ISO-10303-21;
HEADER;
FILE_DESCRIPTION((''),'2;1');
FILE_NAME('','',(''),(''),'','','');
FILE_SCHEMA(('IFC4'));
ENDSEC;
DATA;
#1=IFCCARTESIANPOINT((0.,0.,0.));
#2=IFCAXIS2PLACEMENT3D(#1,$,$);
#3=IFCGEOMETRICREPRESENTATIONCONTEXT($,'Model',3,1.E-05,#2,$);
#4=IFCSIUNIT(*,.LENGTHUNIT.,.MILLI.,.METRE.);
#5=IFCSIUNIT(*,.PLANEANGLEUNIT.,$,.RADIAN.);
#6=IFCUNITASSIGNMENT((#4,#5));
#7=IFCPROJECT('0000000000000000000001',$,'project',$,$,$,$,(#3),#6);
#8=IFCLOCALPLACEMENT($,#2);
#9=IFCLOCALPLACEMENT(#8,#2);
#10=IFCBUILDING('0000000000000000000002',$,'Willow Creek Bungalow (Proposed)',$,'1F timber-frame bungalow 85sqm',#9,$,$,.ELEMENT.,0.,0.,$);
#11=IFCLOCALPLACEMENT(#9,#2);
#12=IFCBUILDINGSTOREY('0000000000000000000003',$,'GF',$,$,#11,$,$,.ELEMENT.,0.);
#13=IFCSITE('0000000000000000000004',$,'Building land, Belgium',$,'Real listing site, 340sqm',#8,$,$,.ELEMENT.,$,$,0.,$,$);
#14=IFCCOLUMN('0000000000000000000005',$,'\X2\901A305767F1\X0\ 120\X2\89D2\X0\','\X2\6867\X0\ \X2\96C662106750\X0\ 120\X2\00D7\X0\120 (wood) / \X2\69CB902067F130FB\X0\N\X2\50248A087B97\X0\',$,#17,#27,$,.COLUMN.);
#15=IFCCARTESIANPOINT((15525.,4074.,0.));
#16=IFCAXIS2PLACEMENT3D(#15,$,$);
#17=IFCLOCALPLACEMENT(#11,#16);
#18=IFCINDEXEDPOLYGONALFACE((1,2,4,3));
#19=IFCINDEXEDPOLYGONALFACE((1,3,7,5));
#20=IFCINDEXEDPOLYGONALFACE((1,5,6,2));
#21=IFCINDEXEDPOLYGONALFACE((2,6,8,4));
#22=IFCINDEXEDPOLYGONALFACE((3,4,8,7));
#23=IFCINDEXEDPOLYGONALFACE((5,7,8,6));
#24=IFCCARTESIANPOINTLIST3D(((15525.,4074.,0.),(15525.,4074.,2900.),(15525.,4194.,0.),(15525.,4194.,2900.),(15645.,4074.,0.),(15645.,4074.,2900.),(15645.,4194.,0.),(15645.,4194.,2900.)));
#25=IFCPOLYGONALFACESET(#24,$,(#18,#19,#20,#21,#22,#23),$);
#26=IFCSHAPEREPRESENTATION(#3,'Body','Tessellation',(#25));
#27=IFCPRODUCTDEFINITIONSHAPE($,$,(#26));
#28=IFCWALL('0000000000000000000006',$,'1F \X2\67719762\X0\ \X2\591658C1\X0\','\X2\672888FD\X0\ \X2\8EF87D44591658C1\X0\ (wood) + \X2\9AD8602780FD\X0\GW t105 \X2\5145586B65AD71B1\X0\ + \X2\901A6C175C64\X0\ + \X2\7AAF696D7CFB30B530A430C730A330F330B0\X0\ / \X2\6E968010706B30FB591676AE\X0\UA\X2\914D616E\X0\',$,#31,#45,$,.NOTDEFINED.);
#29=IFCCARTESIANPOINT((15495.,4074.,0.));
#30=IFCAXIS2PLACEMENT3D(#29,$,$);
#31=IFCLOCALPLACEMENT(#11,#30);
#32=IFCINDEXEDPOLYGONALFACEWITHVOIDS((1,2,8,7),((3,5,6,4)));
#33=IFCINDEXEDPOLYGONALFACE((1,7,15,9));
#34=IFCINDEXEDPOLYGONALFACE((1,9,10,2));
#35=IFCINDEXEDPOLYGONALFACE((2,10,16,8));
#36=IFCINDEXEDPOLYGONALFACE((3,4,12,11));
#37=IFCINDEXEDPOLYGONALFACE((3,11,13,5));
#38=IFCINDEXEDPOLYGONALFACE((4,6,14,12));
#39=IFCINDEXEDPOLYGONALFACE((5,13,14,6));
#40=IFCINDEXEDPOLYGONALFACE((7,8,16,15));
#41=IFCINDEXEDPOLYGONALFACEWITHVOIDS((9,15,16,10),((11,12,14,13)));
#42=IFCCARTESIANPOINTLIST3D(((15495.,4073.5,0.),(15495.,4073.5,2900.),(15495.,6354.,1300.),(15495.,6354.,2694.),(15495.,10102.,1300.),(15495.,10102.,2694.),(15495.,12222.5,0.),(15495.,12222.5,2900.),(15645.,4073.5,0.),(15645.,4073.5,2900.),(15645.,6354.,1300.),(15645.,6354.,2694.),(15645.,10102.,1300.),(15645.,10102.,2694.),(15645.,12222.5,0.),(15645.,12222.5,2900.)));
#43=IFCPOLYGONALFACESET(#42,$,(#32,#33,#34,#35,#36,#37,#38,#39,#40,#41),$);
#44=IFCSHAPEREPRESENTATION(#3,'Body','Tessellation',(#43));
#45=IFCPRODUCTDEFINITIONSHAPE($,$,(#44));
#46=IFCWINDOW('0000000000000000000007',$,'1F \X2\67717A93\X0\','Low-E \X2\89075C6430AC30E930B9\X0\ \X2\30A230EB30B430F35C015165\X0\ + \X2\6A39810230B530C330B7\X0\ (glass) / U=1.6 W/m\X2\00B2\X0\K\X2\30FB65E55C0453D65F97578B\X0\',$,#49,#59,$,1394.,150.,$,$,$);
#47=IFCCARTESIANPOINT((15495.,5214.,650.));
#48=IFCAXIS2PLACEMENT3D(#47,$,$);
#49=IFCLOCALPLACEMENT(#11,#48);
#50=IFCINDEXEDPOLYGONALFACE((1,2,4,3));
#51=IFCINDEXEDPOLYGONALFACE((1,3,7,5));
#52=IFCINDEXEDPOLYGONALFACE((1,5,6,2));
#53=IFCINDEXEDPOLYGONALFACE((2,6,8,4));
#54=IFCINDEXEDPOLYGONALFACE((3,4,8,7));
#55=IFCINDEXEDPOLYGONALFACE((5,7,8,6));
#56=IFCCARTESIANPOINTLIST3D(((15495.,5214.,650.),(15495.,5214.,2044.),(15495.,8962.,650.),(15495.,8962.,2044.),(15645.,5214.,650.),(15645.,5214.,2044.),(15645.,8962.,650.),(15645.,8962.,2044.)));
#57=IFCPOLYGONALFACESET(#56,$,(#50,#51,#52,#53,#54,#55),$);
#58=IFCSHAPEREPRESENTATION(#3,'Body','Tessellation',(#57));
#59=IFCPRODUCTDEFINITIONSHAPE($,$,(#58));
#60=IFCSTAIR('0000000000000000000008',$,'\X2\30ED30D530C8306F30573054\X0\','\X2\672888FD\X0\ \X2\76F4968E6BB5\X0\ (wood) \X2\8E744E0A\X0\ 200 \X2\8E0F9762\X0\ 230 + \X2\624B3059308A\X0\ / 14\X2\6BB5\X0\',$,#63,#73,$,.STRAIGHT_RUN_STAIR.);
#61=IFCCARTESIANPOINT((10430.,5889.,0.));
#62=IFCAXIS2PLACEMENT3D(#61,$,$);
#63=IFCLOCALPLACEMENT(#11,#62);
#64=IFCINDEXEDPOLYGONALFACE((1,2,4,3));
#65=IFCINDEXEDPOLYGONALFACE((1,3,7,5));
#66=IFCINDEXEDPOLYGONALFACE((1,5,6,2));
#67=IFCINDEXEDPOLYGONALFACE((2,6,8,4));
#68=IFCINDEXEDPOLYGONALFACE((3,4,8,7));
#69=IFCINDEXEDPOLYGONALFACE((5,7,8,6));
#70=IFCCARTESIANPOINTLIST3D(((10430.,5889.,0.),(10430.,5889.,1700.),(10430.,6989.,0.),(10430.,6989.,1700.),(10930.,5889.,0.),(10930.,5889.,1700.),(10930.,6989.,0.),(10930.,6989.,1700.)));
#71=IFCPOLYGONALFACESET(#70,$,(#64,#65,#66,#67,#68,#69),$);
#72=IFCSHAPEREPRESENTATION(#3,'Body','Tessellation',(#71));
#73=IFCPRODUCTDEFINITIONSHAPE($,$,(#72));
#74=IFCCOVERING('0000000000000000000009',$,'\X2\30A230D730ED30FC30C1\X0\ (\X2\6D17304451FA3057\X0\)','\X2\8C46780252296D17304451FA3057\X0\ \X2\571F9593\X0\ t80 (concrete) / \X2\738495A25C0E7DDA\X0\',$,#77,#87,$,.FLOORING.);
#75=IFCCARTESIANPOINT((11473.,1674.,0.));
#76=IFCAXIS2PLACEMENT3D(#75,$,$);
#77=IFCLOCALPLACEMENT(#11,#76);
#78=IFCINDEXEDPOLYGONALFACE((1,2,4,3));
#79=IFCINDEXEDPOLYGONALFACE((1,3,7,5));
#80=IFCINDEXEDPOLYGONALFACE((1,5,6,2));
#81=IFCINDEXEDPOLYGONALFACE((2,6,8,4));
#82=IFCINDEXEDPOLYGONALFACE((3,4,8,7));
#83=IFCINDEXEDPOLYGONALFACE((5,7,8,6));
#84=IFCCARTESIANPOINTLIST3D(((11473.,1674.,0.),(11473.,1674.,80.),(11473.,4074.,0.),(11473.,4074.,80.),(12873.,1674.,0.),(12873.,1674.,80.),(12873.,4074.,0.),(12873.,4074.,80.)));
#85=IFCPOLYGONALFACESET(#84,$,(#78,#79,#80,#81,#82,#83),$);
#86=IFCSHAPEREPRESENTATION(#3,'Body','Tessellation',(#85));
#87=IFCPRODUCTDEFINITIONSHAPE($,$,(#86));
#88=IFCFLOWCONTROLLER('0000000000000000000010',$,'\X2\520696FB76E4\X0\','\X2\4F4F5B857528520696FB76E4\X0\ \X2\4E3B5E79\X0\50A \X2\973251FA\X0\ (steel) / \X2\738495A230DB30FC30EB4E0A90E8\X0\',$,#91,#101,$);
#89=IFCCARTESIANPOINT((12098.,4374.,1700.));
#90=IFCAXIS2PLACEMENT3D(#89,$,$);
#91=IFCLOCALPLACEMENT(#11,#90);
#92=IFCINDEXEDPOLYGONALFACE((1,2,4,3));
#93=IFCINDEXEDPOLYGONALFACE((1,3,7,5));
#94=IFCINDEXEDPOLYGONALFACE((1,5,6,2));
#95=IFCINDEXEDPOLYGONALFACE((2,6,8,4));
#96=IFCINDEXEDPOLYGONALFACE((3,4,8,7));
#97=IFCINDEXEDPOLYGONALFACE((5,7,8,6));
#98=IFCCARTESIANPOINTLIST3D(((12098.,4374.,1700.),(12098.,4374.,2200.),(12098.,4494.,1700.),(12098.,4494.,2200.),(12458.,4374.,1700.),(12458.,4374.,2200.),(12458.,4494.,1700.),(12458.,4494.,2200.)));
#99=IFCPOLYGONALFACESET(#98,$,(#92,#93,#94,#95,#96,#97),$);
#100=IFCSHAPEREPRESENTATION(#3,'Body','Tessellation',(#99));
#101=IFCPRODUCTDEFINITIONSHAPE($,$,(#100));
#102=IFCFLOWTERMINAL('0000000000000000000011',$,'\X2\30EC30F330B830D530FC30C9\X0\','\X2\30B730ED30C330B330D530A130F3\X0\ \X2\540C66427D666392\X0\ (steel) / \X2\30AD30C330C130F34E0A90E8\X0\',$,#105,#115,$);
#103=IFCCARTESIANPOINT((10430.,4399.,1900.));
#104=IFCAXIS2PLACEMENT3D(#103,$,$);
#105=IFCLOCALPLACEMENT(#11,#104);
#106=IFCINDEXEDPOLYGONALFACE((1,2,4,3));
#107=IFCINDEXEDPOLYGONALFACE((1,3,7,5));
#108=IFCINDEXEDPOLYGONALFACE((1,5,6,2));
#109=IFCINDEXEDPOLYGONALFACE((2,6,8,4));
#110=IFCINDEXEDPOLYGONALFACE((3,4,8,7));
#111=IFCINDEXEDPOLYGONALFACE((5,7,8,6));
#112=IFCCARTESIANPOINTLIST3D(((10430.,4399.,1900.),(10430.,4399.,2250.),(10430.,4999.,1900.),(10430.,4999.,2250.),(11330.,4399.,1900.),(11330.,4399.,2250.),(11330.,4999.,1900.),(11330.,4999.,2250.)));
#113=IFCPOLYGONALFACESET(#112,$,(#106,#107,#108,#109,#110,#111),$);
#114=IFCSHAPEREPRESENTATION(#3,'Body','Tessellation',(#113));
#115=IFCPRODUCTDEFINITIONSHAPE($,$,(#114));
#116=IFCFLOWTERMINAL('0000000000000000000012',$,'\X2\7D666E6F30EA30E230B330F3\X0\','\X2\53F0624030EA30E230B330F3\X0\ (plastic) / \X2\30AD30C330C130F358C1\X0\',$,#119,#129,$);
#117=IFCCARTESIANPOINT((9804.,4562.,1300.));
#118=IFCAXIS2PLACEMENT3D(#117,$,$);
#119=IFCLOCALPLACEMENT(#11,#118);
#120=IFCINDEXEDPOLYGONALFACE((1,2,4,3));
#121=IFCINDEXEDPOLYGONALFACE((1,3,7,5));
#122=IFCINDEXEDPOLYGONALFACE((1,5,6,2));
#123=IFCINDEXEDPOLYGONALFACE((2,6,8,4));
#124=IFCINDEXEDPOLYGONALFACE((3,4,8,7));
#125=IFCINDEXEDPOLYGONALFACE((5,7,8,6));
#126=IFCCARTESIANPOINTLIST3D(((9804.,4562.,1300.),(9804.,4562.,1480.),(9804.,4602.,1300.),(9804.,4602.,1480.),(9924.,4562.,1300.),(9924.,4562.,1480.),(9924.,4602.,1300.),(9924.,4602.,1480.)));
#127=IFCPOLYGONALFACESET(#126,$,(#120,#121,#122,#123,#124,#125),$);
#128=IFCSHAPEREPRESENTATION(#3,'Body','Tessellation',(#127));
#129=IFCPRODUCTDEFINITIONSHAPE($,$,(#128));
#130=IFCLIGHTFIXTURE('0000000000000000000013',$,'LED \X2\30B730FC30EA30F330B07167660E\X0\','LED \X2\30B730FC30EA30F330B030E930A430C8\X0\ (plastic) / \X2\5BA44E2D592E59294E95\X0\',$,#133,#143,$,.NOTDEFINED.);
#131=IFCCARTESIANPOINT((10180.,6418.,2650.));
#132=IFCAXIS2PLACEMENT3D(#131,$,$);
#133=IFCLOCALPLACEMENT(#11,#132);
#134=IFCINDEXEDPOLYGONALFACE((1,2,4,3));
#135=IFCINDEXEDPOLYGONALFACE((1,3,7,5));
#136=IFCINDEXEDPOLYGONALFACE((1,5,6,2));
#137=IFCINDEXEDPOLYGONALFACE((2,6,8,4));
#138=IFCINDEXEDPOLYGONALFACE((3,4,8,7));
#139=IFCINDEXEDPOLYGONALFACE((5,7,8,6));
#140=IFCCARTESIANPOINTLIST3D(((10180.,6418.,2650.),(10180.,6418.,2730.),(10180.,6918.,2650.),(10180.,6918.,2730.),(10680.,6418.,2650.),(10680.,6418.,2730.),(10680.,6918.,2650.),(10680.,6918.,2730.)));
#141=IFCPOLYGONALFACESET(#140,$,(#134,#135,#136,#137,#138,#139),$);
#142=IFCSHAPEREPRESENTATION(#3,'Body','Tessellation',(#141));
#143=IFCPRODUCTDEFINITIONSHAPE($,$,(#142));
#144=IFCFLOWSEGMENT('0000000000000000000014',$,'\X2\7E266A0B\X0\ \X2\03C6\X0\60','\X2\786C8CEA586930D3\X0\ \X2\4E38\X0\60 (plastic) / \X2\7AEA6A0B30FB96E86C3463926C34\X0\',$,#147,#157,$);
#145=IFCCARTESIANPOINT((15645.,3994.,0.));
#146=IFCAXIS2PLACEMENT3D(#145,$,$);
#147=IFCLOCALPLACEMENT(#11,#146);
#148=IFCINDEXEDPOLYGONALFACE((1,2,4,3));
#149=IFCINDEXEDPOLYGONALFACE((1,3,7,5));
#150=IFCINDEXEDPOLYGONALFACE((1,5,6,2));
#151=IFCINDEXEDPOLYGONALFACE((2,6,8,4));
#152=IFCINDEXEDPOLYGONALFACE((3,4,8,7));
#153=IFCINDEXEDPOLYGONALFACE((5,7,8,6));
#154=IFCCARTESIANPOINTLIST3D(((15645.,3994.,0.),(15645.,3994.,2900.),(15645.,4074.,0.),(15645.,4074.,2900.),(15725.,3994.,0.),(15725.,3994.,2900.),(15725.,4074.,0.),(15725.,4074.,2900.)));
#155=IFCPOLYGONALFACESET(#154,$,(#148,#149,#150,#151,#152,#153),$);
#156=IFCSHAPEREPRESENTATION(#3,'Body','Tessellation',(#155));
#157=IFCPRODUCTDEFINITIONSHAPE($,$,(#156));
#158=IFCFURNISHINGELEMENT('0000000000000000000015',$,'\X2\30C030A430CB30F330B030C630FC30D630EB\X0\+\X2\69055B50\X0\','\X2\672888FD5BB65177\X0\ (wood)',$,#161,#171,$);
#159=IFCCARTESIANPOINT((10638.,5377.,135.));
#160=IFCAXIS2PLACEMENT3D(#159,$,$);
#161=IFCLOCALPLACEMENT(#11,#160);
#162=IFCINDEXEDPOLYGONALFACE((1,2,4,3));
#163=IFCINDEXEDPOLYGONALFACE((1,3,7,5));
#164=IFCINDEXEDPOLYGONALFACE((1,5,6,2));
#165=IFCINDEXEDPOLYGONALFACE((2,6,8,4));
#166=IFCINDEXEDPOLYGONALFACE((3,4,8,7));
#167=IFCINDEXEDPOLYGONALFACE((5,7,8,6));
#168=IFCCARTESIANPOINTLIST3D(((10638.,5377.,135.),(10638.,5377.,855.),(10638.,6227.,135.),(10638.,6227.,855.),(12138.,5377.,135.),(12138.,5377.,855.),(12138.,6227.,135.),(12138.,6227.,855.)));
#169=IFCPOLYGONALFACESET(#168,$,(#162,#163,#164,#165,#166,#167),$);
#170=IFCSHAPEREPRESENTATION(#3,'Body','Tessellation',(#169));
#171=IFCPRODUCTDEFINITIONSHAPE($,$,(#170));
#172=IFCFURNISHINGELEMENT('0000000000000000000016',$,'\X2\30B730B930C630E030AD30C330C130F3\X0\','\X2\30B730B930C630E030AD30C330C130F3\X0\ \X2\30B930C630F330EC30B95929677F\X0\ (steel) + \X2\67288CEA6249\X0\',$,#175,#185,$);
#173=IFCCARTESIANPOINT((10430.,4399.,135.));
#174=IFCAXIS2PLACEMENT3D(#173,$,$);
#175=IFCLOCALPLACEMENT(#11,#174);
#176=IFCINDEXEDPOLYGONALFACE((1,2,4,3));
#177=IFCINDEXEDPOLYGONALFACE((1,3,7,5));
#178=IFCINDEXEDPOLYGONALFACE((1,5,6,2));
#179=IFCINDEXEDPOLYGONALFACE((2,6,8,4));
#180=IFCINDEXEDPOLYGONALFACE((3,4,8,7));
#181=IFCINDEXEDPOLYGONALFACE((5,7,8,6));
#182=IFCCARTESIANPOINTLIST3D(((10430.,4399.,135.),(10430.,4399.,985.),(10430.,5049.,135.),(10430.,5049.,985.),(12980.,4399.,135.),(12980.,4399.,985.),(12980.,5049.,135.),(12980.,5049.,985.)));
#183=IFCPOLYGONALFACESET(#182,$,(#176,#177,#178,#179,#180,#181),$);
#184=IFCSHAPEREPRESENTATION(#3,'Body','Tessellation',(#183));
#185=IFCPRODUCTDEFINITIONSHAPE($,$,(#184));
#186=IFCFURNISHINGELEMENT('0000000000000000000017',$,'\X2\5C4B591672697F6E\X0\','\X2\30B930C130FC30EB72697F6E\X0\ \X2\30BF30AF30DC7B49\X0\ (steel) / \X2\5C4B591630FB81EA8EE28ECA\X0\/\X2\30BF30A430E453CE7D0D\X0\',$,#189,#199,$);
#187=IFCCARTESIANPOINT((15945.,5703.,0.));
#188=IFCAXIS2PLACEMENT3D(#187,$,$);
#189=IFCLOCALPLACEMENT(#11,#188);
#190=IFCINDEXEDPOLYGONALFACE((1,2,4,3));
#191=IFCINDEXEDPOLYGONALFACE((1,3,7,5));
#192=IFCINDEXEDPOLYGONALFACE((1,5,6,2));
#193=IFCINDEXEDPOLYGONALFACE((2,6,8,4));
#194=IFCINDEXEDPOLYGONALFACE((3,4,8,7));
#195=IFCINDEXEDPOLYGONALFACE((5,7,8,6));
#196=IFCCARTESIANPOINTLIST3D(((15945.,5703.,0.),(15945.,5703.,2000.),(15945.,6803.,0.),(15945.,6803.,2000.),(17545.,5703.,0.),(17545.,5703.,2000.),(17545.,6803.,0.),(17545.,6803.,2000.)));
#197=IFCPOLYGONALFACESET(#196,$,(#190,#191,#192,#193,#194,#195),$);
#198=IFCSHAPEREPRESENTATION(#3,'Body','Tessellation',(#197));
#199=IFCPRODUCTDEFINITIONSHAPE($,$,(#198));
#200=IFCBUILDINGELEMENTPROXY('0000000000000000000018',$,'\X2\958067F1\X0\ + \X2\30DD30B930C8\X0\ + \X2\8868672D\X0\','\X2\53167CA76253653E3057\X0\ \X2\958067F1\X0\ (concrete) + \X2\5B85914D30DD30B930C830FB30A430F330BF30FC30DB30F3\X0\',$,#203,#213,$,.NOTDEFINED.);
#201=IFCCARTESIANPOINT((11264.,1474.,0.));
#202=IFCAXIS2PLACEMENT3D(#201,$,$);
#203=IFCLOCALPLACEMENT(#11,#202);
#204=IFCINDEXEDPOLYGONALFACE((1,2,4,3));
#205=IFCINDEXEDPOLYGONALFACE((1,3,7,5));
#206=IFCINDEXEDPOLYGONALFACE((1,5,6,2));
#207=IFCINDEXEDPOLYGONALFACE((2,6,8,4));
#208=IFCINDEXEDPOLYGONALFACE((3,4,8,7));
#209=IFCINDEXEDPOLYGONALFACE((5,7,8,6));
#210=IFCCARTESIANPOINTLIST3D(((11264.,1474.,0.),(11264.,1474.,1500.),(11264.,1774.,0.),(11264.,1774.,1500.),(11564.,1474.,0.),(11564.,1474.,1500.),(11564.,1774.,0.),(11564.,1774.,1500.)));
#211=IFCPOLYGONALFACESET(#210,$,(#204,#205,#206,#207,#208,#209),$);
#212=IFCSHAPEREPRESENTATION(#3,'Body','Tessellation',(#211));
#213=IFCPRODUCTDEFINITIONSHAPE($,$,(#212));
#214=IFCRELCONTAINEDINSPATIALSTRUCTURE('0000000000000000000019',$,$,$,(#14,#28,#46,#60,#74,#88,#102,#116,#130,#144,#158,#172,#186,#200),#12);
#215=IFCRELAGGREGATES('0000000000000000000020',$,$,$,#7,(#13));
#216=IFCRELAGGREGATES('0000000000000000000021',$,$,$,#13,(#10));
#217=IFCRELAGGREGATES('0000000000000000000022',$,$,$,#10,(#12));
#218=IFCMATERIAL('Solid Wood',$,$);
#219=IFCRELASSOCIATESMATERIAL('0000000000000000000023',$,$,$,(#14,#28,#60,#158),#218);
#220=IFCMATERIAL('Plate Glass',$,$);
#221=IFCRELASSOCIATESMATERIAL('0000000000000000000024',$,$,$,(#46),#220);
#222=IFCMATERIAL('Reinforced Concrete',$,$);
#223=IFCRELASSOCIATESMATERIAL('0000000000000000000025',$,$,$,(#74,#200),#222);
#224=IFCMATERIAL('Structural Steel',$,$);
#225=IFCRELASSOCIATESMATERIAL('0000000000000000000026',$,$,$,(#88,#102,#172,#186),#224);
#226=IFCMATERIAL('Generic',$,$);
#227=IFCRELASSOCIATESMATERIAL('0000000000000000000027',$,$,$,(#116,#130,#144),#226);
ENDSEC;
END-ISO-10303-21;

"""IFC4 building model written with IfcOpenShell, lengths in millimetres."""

from ifc_helpers import new_model, si_unit, frame, frame_2d, origin, place, context, project, spatial, rectangle, extrude, material, element, fill, save


model = new_model("IFC4")

# Units and contexts
model_context = context("Model", 3, precision=1e-05, world=origin())
ifc_project = project(units=[si_unit("LENGTHUNIT", "METRE", prefix="MILLI"), si_unit("PLANEANGLEUNIT", "RADIAN")], contexts=[model_context])

# Site, building, storey
site_placement = place(None, origin())
site = spatial("IfcSite", under=ifc_project, at=site_placement, Name="Building land, Belgium", ObjectType="Real listing site, 340sqm", CompositionType="ELEMENT", RefElevation=0.0)
building_placement = place(site_placement, origin())
building = spatial("IfcBuilding", under=site, at=building_placement, Name="Willow Creek Bungalow (Proposed)", ObjectType="1F timber-frame bungalow 85sqm", CompositionType="ELEMENT", ElevationOfRefHeight=0.0, ElevationOfTerrain=0.0)
storey_placement = place(building_placement, origin())
storey = spatial("IfcBuildingStorey", under=building, at=storey_placement, Name="GF", CompositionType="ELEMENT", Elevation=0.0)

# Column
ifc_material_1 = material(Name="Solid Wood")
column_1_placement = place(storey_placement, frame((15525.0, 4074.0, 0.0)))
element("IfcColumn", 1, at=column_1_placement, inside=storey, material=ifc_material_1, Name="通し柱 120角", Description="桧 集成材 120×120 (wood) / 構造柱・N値計算", PredefinedType="COLUMN", context=model_context, shape_type="SweptSolid", body=[
    extrude(rectangle(XDim=120.0, YDim=120.0, at=frame_2d((60.0, 60.0))), frame((15525.0, 4074.0, 0.0)), (0.0, 0.0, 1.0), 2900.0),
])

# Wall, opening, window
wall_1_placement = place(storey_placement, frame((15495.0, 4074.0, 0.0)))
wall_1 = element("IfcWall", 2, at=wall_1_placement, inside=storey, material=ifc_material_1, Name="1F 東面 外壁", Description="木製 軸組外壁 (wood) + 高性能GW t105 充填断熱 + 通気層 + 窯業系サイディング / 準耐火・外皮UA配慮", PredefinedType="NOTDEFINED", context=model_context, shape_type="SweptSolid", body=[
    extrude(rectangle(XDim=150.0, YDim=8149.0, at=frame_2d((75.0, 4074.0))), frame((15495.0, 4074.0, 0.0)), (0.0, 0.0, 1.0), 2900.0),
])
opening_placement = place(storey_placement, frame((15495.0, 5214.0, 650.0)))
opening = element("IfcOpeningElement", 3, at=opening_placement, cuts=wall_1, PredefinedType="NOTDEFINED", context=model_context, shape_type="SweptSolid", body=[
    extrude(rectangle(XDim=150.0, YDim=3748.0, at=frame_2d((75.0, 1874.0))), frame((15495.0, 5214.0, 650.0)), (0.0, 0.0, 1.0), 1394.0),
])
ifc_material_2 = material(Name="Plate Glass")
window_placement = place(storey_placement, frame((15495.0, 5214.0, 650.0)))
window = element("IfcWindow", 4, at=window_placement, inside=storey, material=ifc_material_2, Name="1F 東窓", Description="Low-E 複層ガラス アルゴン封入 + 樹脂サッシ (glass) / U=1.6 W/m²K・日射取得型", OverallHeight=1394.0, OverallWidth=150.0, context=model_context, shape_type="SweptSolid", body=[
    extrude(rectangle(XDim=150.0, YDim=3748.0, at=frame_2d((75.0, 1874.0))), frame((15495.0, 5214.0, 650.0)), (0.0, 0.0, 1.0), 1394.0),
])
fill(opening, window)

# Stair
stair_placement = place(storey_placement, frame((10430.0, 5889.0, 0.0)))
element("IfcStair", 5, at=stair_placement, inside=storey, material=ifc_material_1, Name="ロフトはしご", Description="木製 直階段 (wood) 蹴上 200 踏面 230 + 手すり / 14段", PredefinedType="STRAIGHT_RUN_STAIR", context=model_context, shape_type="SweptSolid", body=[
    extrude(rectangle(XDim=500.0, YDim=1100.0, at=frame_2d((250.0, 550.0))), frame((10430.0, 5889.0, 0.0)), (0.0, 0.0, 1.0), 1700.0),
])

# Covering
ifc_material_3 = material(Name="Reinforced Concrete")
covering_placement = place(storey_placement, frame((11473.0, 1674.0, 0.0)))
element("IfcCovering", 6, at=covering_placement, inside=storey, material=ifc_material_3, Name="アプローチ (洗い出し)", Description="豆砂利洗い出し 土間 t80 (concrete) / 玄関導線", PredefinedType="FLOORING", context=model_context, shape_type="SweptSolid", body=[
    extrude(rectangle(XDim=1400.0, YDim=2400.0, at=frame_2d((700.0, 1200.0))), frame((11473.0, 1674.0, 0.0)), (0.0, 0.0, 1.0), 80.0),
])

# Flow controller
ifc_material_4 = material(Name="Structural Steel")
flow_controller_placement = place(storey_placement, frame((12098.0, 4374.0, 1700.0)))
element("IfcFlowController", 7, at=flow_controller_placement, inside=storey, material=ifc_material_4, Name="分電盤", Description="住宅用分電盤 主幹50A 露出 (steel) / 玄関ホール上部", context=model_context, shape_type="SweptSolid", body=[
    extrude(rectangle(XDim=360.0, YDim=120.0, at=frame_2d((180.0, 60.0))), frame((12098.0, 4374.0, 1700.0)), (0.0, 0.0, 1.0), 500.0),
])

# Flow terminals
flow_terminal_1_placement = place(storey_placement, frame((10430.0, 4399.0, 1900.0)))
element("IfcFlowTerminal", 8, at=flow_terminal_1_placement, inside=storey, material=ifc_material_4, Name="レンジフード", Description="シロッコファン 同時給排 (steel) / キッチン上部", context=model_context, shape_type="SweptSolid", body=[
    extrude(rectangle(XDim=900.0, YDim=600.0, at=frame_2d((450.0, 300.0))), frame((10430.0, 4399.0, 1900.0)), (0.0, 0.0, 1.0), 350.0),
])
ifc_material_5 = material(Name="Generic")
flow_terminal_2_placement = place(storey_placement, frame((9804.0, 4562.0, 1300.0)))
element("IfcFlowTerminal", 9, at=flow_terminal_2_placement, inside=storey, material=ifc_material_5, Name="給湯リモコン", Description="台所リモコン (plastic) / キッチン壁", context=model_context, shape_type="SweptSolid", body=[
    extrude(rectangle(XDim=120.0, YDim=40.0, at=frame_2d((60.0, 20.0))), frame((9804.0, 4562.0, 1300.0)), (0.0, 0.0, 1.0), 180.0),
])

# Light fixture
light_fixture_placement = place(storey_placement, frame((10180.0, 6418.0, 2650.0)))
element("IfcLightFixture", 10, at=light_fixture_placement, inside=storey, material=ifc_material_5, Name="LED シーリング照明", Description="LED シーリングライト (plastic) / 室中央天井", PredefinedType="NOTDEFINED", context=model_context, shape_type="SweptSolid", body=[
    extrude(rectangle(XDim=500.0, YDim=500.0, at=frame_2d((250.0, 250.0))), frame((10180.0, 6418.0, 2650.0)), (0.0, 0.0, 1.0), 80.0),
])

# Flow segment
flow_segment_placement = place(storey_placement, frame((15645.0, 3994.0, 0.0)))
element("IfcFlowSegment", 11, at=flow_segment_placement, inside=storey, material=ifc_material_5, Name="縦樋 φ60", Description="硬質塩ビ 丸60 (plastic) / 竪樋・雨水排水", context=model_context, shape_type="SweptSolid", body=[
    extrude(rectangle(XDim=80.0, YDim=80.0, at=frame_2d((40.0, 40.0))), frame((15645.0, 3994.0, 0.0)), (0.0, 0.0, 1.0), 2900.0),
])

# Furnishing elements
furnishing_1_placement = place(storey_placement, frame((10638.0, 5377.0, 135.0)))
element("IfcFurnishingElement", 12, at=furnishing_1_placement, inside=storey, material=ifc_material_1, Name="ダイニングテーブル+椅子", Description="木製家具 (wood)", context=model_context, shape_type="SweptSolid", body=[
    extrude(rectangle(XDim=1500.0, YDim=850.0, at=frame_2d((750.0, 425.0))), frame((10638.0, 5377.0, 135.0)), (0.0, 0.0, 1.0), 720.0),
])
furnishing_2_placement = place(storey_placement, frame((10430.0, 4399.0, 135.0)))
element("IfcFurnishingElement", 13, at=furnishing_2_placement, inside=storey, material=ifc_material_4, Name="システムキッチン", Description="システムキッチン ステンレス天板 (steel) + 木質扉", context=model_context, shape_type="SweptSolid", body=[
    extrude(rectangle(XDim=2550.0, YDim=650.0, at=frame_2d((1275.0, 325.0))), frame((10430.0, 4399.0, 135.0)), (0.0, 0.0, 1.0), 850.0),
])
furnishing_3_placement = place(storey_placement, frame((15945.0, 5703.0, 0.0)))
element("IfcFurnishingElement", 14, at=furnishing_3_placement, inside=storey, material=ifc_material_4, Name="屋外物置", Description="スチール物置 タクボ等 (steel) / 屋外・自転車/タイヤ収納", context=model_context, shape_type="SweptSolid", body=[
    extrude(rectangle(XDim=1600.0, YDim=1100.0, at=frame_2d((800.0, 550.0))), frame((15945.0, 5703.0, 0.0)), (0.0, 0.0, 1.0), 2000.0),
])

# Building element proxy
proxy_placement = place(storey_placement, frame((11264.0, 1474.0, 0.0)))
element("IfcBuildingElementProxy", 15, at=proxy_placement, inside=storey, material=ifc_material_3, Name="門柱 + ポスト + 表札", Description="化粧打放し 門柱 (concrete) + 宅配ポスト・インターホン", PredefinedType="NOTDEFINED", context=model_context, shape_type="SweptSolid", body=[
    extrude(rectangle(XDim=300.0, YDim=300.0, at=frame_2d((150.0, 150.0))), frame((11264.0, 1474.0, 0.0)), (0.0, 0.0, 1.0), 1500.0),
])

save(model, "model.ifc")
